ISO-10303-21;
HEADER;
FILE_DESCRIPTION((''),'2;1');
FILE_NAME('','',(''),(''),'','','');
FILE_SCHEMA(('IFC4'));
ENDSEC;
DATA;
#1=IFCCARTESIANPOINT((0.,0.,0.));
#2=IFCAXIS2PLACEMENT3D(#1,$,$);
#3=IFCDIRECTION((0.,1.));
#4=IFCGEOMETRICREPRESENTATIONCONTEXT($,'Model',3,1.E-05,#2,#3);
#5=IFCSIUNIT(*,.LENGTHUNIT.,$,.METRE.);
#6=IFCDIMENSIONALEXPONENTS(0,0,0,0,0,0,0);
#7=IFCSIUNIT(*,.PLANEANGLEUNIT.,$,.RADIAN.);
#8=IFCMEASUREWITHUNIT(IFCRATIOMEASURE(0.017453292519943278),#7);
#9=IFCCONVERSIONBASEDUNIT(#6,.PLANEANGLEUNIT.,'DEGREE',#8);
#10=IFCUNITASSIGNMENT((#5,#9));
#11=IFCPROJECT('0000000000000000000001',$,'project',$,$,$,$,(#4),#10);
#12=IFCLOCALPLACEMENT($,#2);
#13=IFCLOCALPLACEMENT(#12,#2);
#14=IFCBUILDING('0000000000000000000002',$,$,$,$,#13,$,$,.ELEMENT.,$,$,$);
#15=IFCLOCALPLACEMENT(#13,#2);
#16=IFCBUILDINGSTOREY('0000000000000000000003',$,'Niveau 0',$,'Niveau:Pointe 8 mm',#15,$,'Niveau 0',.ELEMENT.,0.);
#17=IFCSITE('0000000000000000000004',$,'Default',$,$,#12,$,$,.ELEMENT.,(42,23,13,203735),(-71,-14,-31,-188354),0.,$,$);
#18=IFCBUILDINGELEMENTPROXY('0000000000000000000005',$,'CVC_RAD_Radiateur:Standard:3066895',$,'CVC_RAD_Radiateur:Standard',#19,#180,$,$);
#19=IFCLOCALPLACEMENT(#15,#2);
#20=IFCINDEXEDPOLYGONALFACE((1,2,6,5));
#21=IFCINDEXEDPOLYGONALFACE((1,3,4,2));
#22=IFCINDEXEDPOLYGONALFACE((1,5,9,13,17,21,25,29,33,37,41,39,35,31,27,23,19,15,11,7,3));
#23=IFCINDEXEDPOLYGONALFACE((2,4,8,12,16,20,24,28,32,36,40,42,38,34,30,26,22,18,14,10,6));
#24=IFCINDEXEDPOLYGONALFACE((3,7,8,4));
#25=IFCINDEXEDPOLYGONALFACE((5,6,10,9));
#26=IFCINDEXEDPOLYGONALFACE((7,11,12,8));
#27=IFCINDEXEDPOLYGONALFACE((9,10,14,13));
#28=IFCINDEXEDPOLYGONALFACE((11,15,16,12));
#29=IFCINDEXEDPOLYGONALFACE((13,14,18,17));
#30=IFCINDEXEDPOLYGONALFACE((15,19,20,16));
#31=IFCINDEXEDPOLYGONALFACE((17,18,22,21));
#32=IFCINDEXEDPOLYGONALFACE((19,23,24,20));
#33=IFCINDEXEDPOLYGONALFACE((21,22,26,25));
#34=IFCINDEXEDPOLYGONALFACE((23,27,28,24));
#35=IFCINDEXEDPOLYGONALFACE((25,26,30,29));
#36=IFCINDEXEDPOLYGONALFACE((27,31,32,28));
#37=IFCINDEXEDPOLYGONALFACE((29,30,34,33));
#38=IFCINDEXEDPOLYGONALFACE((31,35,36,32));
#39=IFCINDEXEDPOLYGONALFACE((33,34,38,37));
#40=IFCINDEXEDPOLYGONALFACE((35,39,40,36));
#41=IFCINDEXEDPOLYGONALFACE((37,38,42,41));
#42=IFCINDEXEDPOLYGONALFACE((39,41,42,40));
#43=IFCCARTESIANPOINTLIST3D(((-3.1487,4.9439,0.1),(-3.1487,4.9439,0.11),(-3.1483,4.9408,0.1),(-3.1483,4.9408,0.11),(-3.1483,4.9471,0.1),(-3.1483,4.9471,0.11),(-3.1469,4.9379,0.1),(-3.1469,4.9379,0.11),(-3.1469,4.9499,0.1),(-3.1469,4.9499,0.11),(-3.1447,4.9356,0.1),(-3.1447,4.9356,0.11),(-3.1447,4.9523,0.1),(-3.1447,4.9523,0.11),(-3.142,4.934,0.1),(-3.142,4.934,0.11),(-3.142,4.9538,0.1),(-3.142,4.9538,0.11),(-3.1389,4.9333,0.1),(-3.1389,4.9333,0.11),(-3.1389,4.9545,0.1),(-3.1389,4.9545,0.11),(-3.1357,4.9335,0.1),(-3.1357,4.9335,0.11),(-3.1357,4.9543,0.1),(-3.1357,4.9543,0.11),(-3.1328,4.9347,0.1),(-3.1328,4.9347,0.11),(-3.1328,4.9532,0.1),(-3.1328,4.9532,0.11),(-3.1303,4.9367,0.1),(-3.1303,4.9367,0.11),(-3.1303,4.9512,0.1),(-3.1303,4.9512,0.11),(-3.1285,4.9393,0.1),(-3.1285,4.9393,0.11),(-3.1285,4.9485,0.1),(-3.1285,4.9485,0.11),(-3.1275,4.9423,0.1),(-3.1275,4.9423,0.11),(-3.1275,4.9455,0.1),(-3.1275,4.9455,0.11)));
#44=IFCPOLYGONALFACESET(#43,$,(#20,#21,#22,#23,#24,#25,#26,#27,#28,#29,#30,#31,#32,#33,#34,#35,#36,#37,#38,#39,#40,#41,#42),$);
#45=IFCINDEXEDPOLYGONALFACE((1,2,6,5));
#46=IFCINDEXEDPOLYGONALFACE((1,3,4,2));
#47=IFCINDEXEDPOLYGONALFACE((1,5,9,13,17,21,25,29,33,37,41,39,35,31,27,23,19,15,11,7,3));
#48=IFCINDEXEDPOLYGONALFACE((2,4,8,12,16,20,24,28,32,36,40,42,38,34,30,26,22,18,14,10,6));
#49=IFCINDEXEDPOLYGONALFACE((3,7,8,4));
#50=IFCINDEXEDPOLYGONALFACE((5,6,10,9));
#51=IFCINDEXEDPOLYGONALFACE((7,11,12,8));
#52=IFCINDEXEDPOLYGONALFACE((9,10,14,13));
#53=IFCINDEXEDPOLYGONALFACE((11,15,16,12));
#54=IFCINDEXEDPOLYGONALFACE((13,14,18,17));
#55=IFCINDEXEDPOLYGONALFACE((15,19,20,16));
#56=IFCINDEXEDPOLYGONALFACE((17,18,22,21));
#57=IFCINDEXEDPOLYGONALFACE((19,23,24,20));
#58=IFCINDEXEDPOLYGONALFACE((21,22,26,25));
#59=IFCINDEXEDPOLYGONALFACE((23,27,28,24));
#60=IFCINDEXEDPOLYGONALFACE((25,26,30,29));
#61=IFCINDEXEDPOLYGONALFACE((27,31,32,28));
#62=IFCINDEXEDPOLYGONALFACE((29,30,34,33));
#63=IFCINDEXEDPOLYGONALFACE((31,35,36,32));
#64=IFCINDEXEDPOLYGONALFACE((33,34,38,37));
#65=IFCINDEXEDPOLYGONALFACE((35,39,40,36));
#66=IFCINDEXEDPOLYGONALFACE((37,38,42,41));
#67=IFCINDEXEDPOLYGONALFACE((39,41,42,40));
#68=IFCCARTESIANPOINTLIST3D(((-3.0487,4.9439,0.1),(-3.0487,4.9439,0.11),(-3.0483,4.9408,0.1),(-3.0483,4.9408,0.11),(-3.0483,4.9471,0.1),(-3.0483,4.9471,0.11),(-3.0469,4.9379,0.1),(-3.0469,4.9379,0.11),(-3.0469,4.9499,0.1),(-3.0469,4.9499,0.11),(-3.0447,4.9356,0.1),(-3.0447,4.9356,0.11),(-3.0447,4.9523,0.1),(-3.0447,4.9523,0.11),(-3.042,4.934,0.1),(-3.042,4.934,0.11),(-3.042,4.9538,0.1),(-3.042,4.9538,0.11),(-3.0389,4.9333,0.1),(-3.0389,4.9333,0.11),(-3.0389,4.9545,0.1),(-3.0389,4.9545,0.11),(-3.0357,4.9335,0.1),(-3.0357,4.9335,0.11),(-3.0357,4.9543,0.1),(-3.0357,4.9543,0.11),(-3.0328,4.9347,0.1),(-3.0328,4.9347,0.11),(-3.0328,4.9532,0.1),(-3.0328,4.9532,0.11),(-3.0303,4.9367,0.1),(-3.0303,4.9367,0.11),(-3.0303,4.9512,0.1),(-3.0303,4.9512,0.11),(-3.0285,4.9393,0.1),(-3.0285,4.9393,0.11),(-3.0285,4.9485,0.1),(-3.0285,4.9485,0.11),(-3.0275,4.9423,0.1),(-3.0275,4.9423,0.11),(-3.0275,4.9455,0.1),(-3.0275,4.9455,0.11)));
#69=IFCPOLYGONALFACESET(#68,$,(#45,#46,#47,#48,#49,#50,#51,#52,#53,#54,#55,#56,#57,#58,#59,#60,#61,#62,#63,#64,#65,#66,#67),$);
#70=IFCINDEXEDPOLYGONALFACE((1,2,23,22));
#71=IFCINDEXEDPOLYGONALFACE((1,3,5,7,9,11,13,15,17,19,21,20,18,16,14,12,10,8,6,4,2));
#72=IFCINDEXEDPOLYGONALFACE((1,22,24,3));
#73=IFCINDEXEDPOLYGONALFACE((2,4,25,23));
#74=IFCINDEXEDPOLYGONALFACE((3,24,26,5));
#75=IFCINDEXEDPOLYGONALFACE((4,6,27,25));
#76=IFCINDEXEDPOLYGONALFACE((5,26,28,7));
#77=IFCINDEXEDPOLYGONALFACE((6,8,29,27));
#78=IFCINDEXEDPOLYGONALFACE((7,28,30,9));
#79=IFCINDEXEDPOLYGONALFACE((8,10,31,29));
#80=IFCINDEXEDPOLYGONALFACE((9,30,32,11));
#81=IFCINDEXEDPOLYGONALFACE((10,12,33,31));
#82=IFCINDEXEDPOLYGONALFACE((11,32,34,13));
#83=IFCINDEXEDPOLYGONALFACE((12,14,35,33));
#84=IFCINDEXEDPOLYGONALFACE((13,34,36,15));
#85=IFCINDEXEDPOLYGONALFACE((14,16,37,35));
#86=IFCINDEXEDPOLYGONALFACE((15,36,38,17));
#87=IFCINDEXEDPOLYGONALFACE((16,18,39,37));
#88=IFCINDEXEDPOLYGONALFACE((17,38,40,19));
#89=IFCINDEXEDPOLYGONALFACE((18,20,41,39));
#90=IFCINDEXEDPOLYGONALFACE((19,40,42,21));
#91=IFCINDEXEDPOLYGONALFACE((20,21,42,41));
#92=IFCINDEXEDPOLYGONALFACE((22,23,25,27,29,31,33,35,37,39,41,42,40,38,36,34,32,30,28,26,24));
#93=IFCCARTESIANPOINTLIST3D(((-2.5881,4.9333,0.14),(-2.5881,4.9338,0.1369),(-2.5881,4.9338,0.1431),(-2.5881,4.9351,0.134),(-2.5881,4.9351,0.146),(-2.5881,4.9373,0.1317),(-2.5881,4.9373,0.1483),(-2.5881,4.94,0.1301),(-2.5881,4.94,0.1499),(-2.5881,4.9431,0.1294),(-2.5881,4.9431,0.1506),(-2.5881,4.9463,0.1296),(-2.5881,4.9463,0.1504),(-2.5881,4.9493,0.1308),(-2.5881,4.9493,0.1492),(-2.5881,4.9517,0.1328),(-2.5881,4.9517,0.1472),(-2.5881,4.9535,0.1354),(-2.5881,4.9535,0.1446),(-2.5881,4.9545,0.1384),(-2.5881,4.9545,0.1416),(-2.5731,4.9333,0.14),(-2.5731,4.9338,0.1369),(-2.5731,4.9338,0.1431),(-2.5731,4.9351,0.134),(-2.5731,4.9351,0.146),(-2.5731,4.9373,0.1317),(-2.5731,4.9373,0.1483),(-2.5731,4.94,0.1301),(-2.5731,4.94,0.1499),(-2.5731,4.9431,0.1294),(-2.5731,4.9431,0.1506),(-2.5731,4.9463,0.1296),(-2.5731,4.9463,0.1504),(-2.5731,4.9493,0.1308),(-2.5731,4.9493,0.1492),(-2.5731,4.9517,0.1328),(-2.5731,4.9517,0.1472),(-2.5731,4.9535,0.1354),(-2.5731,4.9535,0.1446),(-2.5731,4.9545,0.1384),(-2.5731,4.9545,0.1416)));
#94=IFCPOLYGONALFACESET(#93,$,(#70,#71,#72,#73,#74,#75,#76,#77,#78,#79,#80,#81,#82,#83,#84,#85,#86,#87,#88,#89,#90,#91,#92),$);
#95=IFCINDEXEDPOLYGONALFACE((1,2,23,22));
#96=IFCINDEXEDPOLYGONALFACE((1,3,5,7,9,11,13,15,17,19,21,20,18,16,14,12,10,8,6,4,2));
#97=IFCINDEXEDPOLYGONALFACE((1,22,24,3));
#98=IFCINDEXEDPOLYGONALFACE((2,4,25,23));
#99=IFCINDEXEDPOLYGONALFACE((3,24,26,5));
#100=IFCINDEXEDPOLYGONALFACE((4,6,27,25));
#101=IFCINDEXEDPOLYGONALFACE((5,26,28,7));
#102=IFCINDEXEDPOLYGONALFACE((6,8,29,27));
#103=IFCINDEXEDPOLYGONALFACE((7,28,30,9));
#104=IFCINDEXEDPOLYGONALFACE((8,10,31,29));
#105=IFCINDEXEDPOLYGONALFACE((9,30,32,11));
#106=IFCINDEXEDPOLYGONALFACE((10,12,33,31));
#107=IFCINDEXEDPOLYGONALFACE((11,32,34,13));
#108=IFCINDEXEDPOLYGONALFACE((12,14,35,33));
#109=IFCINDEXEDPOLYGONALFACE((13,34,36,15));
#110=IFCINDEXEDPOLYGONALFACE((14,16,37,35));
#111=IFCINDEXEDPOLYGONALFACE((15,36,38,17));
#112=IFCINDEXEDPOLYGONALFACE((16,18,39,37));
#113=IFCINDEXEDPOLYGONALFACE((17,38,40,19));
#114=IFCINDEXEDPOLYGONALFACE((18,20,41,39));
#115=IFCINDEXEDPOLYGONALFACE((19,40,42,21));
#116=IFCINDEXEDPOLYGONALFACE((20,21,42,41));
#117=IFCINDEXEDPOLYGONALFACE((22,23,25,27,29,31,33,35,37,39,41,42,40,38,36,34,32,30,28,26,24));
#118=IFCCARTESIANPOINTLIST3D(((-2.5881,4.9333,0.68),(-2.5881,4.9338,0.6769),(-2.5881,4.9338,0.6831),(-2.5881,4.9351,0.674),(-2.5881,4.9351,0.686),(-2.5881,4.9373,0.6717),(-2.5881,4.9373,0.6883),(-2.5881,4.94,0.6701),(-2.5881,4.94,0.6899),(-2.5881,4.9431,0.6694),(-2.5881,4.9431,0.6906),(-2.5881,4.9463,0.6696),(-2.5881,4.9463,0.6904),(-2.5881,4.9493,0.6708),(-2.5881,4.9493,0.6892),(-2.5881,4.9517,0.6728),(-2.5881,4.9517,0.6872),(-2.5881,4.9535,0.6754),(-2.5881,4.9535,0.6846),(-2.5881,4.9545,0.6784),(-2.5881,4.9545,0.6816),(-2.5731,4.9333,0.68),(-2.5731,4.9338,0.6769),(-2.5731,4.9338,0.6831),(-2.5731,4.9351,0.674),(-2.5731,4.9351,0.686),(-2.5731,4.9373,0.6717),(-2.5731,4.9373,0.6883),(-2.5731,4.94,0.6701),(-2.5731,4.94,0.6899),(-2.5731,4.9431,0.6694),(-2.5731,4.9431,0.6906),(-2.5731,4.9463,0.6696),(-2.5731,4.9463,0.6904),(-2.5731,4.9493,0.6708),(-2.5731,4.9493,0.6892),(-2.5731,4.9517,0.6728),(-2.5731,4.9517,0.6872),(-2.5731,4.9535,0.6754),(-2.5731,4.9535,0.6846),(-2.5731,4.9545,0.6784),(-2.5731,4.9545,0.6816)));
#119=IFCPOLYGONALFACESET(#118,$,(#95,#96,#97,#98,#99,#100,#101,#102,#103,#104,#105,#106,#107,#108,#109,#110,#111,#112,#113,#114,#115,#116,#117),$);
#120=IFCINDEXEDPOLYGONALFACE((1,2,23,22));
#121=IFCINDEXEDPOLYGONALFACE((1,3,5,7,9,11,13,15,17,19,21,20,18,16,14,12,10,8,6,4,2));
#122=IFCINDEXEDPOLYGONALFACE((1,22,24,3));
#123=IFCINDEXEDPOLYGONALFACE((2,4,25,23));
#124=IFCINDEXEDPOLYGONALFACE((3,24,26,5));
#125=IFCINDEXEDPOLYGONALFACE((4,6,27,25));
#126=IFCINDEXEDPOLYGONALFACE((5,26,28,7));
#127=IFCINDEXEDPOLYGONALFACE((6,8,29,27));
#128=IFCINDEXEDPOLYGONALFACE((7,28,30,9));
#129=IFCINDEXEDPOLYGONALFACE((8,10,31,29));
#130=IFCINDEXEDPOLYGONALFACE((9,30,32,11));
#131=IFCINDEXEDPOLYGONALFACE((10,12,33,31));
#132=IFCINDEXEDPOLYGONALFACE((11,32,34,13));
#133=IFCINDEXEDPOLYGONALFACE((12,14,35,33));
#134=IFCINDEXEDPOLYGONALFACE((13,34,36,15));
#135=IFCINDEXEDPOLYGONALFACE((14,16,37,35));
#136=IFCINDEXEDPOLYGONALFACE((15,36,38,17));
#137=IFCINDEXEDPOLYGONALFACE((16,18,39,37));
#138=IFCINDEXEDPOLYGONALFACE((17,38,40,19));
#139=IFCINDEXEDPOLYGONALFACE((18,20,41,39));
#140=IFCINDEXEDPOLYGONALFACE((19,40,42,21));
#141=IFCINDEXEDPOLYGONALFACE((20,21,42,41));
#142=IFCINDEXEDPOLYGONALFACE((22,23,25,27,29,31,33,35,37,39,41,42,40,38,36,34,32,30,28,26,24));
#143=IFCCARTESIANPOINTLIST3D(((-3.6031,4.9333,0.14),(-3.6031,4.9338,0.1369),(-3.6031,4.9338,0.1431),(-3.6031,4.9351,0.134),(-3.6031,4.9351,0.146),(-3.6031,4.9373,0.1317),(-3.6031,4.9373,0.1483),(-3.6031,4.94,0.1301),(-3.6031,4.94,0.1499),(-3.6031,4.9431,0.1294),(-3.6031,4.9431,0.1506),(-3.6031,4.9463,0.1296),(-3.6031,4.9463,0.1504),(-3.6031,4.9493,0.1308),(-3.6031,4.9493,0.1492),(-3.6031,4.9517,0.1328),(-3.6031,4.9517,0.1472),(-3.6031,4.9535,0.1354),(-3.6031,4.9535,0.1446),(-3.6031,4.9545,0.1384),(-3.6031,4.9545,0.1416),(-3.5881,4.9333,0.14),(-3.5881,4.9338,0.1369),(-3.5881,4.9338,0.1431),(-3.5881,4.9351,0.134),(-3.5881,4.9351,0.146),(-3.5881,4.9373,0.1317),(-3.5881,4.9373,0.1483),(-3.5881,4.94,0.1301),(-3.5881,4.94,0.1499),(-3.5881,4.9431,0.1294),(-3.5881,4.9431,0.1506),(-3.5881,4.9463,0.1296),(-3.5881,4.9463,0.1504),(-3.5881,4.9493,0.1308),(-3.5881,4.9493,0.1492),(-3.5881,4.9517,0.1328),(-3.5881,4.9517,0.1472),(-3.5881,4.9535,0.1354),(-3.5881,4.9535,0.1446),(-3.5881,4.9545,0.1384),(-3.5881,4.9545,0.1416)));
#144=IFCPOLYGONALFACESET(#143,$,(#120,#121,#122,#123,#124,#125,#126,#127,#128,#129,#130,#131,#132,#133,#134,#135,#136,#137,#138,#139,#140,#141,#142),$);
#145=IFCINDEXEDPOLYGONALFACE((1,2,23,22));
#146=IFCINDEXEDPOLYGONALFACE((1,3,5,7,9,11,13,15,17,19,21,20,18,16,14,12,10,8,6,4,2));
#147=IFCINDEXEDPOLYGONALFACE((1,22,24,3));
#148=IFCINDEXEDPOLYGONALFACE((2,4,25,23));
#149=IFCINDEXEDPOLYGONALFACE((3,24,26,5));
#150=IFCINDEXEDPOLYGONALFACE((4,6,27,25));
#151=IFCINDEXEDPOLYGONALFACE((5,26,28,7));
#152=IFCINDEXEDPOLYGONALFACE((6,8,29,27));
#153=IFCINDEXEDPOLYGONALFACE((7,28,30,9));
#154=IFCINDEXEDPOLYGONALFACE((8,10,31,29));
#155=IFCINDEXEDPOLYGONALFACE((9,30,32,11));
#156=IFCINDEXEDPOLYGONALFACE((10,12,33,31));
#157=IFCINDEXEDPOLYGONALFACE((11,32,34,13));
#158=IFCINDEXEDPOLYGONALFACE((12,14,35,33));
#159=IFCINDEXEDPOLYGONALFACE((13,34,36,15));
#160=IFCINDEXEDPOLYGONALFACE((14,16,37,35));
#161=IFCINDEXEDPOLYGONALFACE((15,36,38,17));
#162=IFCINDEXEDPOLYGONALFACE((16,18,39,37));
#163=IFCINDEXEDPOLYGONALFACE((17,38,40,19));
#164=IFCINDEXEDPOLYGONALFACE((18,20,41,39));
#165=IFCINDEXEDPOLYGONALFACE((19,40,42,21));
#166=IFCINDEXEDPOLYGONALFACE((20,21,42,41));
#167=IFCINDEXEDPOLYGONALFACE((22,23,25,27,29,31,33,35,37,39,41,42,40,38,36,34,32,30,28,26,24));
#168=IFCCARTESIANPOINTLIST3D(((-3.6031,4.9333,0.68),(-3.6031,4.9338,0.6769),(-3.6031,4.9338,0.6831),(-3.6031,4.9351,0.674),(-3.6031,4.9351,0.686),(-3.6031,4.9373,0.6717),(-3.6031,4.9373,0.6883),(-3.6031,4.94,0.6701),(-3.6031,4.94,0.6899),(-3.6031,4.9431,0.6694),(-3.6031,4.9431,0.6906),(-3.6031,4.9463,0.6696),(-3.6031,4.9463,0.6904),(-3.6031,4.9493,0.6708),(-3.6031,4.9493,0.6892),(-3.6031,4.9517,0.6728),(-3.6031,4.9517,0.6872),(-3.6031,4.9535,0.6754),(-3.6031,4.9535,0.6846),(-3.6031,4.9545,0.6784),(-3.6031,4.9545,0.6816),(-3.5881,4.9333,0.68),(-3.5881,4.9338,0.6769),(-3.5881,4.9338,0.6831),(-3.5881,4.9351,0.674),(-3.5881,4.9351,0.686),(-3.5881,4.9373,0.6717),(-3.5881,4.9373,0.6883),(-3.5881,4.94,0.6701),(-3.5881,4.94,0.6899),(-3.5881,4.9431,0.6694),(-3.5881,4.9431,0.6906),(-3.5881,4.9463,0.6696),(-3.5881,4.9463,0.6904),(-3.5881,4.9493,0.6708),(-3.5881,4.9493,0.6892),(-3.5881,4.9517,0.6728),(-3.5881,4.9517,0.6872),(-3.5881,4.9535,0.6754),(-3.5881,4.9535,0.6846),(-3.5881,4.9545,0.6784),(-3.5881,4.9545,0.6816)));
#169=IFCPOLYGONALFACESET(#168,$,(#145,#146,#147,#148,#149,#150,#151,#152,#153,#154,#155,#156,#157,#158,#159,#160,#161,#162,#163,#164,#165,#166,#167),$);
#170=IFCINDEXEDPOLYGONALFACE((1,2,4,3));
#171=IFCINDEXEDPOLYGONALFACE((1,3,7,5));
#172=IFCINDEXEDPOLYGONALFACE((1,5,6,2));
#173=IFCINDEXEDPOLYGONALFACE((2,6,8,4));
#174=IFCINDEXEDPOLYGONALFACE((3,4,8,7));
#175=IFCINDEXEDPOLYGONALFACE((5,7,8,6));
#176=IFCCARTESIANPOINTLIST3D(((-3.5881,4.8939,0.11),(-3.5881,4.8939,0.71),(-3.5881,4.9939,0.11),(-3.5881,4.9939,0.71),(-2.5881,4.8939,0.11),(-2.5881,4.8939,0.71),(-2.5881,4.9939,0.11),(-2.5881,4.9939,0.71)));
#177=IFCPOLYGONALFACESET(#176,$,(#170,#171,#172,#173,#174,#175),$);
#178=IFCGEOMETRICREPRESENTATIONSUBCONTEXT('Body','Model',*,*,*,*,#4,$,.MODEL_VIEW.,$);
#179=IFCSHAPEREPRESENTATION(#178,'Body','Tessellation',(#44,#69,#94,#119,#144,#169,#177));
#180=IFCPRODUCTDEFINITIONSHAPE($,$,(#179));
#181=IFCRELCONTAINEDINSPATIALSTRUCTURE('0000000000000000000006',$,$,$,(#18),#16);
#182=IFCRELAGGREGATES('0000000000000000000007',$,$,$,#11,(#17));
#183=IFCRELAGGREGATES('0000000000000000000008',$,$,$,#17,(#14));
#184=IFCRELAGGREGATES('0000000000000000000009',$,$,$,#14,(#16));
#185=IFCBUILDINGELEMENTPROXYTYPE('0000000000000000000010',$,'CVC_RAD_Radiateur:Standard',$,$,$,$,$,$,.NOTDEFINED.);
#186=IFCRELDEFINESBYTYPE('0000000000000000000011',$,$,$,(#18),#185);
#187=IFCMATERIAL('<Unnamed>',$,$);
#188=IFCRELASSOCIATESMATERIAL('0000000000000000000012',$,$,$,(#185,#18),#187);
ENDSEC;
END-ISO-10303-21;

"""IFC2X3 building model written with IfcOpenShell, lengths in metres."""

from ifc_helpers import new_model, entity, si_unit, converted_unit, direction, frame, frame_2d, origin, origin_2d_with_axis, place, context, subcontext, project, spatial, rectangle, circle, extrude, source, transform, mapped, material, type_object, type_shapes, element, save


model = new_model("IFC2X3")

# Units and contexts
model_context = context("Model", 3, precision=1e-05, world=origin(), true_north=direction((0.0, 1.0)))
body_context = subcontext(model_context, "Body", "Model", "MODEL_VIEW")
ifc_project = project(units=[si_unit("LENGTHUNIT", "METRE"), converted_unit("PLANEANGLEUNIT", "DEGREE", entity("IfcRatioMeasure", 0.017453292519943278), si_unit("PLANEANGLEUNIT", "RADIAN"), dimensions=[0, 0, 0, 0, 0, 0, 0])], contexts=[model_context])

# Site, building, storey
site_placement = place(None, origin())
site = spatial("IfcSite", under=ifc_project, at=site_placement, Name="Default", CompositionType="ELEMENT", RefLatitude=(42, 23, 13, 203735), RefLongitude=(-71, -14, -31, -188354), RefElevation=0.0)
building_placement = place(site_placement, origin())
building = spatial("IfcBuilding", under=site, at=building_placement, CompositionType="ELEMENT")
storey_placement = place(building_placement, origin())
storey = spatial("IfcBuildingStorey", under=building, at=storey_placement, Name="Niveau 0", ObjectType="Niveau:Pointe 8 mm", LongName="Niveau 0", CompositionType="ELEMENT", Elevation=0.0)

# Building element proxy
ifc_material = material(Name="<Unnamed>")
building_element_proxy_type = type_object("IfcBuildingElementProxyType", Name="CVC_RAD_Radiateur:Standard", PredefinedType="NOTDEFINED", material=ifc_material)
shared_shape = source(origin(), body_context, "Body", "SweptSolid", [
    extrude(circle(Radius=0.0107, at=frame_2d((0.0, 0.0), x_axis=(1.0, 0.0))), frame((0.05, 0.055, 0.0)), (0.0, 0.0, 1.0), 0.01),
    extrude(circle(Radius=0.0107, at=frame_2d((0.0, 0.0), x_axis=(1.0, 0.0))), frame((-0.05, 0.055, 0.0)), (0.0, 0.0, 1.0), 0.01),
    extrude(circle(Radius=0.0107, at=frame_2d((0.0, 0.0), x_axis=(1.0, 0.0))), frame((-0.515, 0.055, 0.04), z_axis=(1.0, 0.0, 0.0), x_axis=(0.0, 1.0, 0.0)), (0.0, 0.0, 1.0), 0.015),
    extrude(circle(Radius=0.0107, at=frame_2d((0.0, 0.0), x_axis=(1.0, 0.0))), frame((-0.515, 0.055, 0.58), z_axis=(1.0, 0.0, 0.0), x_axis=(0.0, 1.0, 0.0)), (0.0, 0.0, 1.0), 0.015),
    extrude(circle(Radius=0.0107, at=frame_2d((0.0, 0.0), x_axis=(1.0, 0.0))), frame((0.5, 0.055, 0.04), z_axis=(1.0, 0.0, 0.0), x_axis=(0.0, 1.0, 0.0)), (0.0, 0.0, 1.0), 0.015),
    extrude(circle(Radius=0.0107, at=origin_2d_with_axis()), frame((0.5, 0.055, 0.58), z_axis=(1.0, 0.0, 0.0), x_axis=(0.0, 1.0, 0.0)), (0.0, 0.0, 1.0), 0.015),
    extrude(rectangle(XDim=1.0, YDim=0.1, at=origin_2d_with_axis()), frame((0.0, 0.055, 0.01), z_axis=(0.0, 0.0, 1.0), x_axis=(-1.0, 0.0, 0.0)), (0.0, 0.0, 1.0), 0.6),
])
type_shapes(building_element_proxy_type, [shared_shape])
proxy_1_placement = place(storey_placement, frame((-3.0881, 4.9989, 0.1), z_axis=(0.0, 0.0, 1.0), x_axis=(-1.0, 0.0, 0.0)))
element("IfcBuildingElementProxy", 1, at=proxy_1_placement, inside=storey, type_object=building_element_proxy_type, material=ifc_material, Name="CVC_RAD_Radiateur:Standard:3066895", ObjectType="CVC_RAD_Radiateur:Standard", context=body_context, shape_type="MappedRepresentation", body=[
    mapped(shared_shape, transform((0.0, 0.0, 0.0), scale=1.0)),
])

save(model, "model.ifc")
